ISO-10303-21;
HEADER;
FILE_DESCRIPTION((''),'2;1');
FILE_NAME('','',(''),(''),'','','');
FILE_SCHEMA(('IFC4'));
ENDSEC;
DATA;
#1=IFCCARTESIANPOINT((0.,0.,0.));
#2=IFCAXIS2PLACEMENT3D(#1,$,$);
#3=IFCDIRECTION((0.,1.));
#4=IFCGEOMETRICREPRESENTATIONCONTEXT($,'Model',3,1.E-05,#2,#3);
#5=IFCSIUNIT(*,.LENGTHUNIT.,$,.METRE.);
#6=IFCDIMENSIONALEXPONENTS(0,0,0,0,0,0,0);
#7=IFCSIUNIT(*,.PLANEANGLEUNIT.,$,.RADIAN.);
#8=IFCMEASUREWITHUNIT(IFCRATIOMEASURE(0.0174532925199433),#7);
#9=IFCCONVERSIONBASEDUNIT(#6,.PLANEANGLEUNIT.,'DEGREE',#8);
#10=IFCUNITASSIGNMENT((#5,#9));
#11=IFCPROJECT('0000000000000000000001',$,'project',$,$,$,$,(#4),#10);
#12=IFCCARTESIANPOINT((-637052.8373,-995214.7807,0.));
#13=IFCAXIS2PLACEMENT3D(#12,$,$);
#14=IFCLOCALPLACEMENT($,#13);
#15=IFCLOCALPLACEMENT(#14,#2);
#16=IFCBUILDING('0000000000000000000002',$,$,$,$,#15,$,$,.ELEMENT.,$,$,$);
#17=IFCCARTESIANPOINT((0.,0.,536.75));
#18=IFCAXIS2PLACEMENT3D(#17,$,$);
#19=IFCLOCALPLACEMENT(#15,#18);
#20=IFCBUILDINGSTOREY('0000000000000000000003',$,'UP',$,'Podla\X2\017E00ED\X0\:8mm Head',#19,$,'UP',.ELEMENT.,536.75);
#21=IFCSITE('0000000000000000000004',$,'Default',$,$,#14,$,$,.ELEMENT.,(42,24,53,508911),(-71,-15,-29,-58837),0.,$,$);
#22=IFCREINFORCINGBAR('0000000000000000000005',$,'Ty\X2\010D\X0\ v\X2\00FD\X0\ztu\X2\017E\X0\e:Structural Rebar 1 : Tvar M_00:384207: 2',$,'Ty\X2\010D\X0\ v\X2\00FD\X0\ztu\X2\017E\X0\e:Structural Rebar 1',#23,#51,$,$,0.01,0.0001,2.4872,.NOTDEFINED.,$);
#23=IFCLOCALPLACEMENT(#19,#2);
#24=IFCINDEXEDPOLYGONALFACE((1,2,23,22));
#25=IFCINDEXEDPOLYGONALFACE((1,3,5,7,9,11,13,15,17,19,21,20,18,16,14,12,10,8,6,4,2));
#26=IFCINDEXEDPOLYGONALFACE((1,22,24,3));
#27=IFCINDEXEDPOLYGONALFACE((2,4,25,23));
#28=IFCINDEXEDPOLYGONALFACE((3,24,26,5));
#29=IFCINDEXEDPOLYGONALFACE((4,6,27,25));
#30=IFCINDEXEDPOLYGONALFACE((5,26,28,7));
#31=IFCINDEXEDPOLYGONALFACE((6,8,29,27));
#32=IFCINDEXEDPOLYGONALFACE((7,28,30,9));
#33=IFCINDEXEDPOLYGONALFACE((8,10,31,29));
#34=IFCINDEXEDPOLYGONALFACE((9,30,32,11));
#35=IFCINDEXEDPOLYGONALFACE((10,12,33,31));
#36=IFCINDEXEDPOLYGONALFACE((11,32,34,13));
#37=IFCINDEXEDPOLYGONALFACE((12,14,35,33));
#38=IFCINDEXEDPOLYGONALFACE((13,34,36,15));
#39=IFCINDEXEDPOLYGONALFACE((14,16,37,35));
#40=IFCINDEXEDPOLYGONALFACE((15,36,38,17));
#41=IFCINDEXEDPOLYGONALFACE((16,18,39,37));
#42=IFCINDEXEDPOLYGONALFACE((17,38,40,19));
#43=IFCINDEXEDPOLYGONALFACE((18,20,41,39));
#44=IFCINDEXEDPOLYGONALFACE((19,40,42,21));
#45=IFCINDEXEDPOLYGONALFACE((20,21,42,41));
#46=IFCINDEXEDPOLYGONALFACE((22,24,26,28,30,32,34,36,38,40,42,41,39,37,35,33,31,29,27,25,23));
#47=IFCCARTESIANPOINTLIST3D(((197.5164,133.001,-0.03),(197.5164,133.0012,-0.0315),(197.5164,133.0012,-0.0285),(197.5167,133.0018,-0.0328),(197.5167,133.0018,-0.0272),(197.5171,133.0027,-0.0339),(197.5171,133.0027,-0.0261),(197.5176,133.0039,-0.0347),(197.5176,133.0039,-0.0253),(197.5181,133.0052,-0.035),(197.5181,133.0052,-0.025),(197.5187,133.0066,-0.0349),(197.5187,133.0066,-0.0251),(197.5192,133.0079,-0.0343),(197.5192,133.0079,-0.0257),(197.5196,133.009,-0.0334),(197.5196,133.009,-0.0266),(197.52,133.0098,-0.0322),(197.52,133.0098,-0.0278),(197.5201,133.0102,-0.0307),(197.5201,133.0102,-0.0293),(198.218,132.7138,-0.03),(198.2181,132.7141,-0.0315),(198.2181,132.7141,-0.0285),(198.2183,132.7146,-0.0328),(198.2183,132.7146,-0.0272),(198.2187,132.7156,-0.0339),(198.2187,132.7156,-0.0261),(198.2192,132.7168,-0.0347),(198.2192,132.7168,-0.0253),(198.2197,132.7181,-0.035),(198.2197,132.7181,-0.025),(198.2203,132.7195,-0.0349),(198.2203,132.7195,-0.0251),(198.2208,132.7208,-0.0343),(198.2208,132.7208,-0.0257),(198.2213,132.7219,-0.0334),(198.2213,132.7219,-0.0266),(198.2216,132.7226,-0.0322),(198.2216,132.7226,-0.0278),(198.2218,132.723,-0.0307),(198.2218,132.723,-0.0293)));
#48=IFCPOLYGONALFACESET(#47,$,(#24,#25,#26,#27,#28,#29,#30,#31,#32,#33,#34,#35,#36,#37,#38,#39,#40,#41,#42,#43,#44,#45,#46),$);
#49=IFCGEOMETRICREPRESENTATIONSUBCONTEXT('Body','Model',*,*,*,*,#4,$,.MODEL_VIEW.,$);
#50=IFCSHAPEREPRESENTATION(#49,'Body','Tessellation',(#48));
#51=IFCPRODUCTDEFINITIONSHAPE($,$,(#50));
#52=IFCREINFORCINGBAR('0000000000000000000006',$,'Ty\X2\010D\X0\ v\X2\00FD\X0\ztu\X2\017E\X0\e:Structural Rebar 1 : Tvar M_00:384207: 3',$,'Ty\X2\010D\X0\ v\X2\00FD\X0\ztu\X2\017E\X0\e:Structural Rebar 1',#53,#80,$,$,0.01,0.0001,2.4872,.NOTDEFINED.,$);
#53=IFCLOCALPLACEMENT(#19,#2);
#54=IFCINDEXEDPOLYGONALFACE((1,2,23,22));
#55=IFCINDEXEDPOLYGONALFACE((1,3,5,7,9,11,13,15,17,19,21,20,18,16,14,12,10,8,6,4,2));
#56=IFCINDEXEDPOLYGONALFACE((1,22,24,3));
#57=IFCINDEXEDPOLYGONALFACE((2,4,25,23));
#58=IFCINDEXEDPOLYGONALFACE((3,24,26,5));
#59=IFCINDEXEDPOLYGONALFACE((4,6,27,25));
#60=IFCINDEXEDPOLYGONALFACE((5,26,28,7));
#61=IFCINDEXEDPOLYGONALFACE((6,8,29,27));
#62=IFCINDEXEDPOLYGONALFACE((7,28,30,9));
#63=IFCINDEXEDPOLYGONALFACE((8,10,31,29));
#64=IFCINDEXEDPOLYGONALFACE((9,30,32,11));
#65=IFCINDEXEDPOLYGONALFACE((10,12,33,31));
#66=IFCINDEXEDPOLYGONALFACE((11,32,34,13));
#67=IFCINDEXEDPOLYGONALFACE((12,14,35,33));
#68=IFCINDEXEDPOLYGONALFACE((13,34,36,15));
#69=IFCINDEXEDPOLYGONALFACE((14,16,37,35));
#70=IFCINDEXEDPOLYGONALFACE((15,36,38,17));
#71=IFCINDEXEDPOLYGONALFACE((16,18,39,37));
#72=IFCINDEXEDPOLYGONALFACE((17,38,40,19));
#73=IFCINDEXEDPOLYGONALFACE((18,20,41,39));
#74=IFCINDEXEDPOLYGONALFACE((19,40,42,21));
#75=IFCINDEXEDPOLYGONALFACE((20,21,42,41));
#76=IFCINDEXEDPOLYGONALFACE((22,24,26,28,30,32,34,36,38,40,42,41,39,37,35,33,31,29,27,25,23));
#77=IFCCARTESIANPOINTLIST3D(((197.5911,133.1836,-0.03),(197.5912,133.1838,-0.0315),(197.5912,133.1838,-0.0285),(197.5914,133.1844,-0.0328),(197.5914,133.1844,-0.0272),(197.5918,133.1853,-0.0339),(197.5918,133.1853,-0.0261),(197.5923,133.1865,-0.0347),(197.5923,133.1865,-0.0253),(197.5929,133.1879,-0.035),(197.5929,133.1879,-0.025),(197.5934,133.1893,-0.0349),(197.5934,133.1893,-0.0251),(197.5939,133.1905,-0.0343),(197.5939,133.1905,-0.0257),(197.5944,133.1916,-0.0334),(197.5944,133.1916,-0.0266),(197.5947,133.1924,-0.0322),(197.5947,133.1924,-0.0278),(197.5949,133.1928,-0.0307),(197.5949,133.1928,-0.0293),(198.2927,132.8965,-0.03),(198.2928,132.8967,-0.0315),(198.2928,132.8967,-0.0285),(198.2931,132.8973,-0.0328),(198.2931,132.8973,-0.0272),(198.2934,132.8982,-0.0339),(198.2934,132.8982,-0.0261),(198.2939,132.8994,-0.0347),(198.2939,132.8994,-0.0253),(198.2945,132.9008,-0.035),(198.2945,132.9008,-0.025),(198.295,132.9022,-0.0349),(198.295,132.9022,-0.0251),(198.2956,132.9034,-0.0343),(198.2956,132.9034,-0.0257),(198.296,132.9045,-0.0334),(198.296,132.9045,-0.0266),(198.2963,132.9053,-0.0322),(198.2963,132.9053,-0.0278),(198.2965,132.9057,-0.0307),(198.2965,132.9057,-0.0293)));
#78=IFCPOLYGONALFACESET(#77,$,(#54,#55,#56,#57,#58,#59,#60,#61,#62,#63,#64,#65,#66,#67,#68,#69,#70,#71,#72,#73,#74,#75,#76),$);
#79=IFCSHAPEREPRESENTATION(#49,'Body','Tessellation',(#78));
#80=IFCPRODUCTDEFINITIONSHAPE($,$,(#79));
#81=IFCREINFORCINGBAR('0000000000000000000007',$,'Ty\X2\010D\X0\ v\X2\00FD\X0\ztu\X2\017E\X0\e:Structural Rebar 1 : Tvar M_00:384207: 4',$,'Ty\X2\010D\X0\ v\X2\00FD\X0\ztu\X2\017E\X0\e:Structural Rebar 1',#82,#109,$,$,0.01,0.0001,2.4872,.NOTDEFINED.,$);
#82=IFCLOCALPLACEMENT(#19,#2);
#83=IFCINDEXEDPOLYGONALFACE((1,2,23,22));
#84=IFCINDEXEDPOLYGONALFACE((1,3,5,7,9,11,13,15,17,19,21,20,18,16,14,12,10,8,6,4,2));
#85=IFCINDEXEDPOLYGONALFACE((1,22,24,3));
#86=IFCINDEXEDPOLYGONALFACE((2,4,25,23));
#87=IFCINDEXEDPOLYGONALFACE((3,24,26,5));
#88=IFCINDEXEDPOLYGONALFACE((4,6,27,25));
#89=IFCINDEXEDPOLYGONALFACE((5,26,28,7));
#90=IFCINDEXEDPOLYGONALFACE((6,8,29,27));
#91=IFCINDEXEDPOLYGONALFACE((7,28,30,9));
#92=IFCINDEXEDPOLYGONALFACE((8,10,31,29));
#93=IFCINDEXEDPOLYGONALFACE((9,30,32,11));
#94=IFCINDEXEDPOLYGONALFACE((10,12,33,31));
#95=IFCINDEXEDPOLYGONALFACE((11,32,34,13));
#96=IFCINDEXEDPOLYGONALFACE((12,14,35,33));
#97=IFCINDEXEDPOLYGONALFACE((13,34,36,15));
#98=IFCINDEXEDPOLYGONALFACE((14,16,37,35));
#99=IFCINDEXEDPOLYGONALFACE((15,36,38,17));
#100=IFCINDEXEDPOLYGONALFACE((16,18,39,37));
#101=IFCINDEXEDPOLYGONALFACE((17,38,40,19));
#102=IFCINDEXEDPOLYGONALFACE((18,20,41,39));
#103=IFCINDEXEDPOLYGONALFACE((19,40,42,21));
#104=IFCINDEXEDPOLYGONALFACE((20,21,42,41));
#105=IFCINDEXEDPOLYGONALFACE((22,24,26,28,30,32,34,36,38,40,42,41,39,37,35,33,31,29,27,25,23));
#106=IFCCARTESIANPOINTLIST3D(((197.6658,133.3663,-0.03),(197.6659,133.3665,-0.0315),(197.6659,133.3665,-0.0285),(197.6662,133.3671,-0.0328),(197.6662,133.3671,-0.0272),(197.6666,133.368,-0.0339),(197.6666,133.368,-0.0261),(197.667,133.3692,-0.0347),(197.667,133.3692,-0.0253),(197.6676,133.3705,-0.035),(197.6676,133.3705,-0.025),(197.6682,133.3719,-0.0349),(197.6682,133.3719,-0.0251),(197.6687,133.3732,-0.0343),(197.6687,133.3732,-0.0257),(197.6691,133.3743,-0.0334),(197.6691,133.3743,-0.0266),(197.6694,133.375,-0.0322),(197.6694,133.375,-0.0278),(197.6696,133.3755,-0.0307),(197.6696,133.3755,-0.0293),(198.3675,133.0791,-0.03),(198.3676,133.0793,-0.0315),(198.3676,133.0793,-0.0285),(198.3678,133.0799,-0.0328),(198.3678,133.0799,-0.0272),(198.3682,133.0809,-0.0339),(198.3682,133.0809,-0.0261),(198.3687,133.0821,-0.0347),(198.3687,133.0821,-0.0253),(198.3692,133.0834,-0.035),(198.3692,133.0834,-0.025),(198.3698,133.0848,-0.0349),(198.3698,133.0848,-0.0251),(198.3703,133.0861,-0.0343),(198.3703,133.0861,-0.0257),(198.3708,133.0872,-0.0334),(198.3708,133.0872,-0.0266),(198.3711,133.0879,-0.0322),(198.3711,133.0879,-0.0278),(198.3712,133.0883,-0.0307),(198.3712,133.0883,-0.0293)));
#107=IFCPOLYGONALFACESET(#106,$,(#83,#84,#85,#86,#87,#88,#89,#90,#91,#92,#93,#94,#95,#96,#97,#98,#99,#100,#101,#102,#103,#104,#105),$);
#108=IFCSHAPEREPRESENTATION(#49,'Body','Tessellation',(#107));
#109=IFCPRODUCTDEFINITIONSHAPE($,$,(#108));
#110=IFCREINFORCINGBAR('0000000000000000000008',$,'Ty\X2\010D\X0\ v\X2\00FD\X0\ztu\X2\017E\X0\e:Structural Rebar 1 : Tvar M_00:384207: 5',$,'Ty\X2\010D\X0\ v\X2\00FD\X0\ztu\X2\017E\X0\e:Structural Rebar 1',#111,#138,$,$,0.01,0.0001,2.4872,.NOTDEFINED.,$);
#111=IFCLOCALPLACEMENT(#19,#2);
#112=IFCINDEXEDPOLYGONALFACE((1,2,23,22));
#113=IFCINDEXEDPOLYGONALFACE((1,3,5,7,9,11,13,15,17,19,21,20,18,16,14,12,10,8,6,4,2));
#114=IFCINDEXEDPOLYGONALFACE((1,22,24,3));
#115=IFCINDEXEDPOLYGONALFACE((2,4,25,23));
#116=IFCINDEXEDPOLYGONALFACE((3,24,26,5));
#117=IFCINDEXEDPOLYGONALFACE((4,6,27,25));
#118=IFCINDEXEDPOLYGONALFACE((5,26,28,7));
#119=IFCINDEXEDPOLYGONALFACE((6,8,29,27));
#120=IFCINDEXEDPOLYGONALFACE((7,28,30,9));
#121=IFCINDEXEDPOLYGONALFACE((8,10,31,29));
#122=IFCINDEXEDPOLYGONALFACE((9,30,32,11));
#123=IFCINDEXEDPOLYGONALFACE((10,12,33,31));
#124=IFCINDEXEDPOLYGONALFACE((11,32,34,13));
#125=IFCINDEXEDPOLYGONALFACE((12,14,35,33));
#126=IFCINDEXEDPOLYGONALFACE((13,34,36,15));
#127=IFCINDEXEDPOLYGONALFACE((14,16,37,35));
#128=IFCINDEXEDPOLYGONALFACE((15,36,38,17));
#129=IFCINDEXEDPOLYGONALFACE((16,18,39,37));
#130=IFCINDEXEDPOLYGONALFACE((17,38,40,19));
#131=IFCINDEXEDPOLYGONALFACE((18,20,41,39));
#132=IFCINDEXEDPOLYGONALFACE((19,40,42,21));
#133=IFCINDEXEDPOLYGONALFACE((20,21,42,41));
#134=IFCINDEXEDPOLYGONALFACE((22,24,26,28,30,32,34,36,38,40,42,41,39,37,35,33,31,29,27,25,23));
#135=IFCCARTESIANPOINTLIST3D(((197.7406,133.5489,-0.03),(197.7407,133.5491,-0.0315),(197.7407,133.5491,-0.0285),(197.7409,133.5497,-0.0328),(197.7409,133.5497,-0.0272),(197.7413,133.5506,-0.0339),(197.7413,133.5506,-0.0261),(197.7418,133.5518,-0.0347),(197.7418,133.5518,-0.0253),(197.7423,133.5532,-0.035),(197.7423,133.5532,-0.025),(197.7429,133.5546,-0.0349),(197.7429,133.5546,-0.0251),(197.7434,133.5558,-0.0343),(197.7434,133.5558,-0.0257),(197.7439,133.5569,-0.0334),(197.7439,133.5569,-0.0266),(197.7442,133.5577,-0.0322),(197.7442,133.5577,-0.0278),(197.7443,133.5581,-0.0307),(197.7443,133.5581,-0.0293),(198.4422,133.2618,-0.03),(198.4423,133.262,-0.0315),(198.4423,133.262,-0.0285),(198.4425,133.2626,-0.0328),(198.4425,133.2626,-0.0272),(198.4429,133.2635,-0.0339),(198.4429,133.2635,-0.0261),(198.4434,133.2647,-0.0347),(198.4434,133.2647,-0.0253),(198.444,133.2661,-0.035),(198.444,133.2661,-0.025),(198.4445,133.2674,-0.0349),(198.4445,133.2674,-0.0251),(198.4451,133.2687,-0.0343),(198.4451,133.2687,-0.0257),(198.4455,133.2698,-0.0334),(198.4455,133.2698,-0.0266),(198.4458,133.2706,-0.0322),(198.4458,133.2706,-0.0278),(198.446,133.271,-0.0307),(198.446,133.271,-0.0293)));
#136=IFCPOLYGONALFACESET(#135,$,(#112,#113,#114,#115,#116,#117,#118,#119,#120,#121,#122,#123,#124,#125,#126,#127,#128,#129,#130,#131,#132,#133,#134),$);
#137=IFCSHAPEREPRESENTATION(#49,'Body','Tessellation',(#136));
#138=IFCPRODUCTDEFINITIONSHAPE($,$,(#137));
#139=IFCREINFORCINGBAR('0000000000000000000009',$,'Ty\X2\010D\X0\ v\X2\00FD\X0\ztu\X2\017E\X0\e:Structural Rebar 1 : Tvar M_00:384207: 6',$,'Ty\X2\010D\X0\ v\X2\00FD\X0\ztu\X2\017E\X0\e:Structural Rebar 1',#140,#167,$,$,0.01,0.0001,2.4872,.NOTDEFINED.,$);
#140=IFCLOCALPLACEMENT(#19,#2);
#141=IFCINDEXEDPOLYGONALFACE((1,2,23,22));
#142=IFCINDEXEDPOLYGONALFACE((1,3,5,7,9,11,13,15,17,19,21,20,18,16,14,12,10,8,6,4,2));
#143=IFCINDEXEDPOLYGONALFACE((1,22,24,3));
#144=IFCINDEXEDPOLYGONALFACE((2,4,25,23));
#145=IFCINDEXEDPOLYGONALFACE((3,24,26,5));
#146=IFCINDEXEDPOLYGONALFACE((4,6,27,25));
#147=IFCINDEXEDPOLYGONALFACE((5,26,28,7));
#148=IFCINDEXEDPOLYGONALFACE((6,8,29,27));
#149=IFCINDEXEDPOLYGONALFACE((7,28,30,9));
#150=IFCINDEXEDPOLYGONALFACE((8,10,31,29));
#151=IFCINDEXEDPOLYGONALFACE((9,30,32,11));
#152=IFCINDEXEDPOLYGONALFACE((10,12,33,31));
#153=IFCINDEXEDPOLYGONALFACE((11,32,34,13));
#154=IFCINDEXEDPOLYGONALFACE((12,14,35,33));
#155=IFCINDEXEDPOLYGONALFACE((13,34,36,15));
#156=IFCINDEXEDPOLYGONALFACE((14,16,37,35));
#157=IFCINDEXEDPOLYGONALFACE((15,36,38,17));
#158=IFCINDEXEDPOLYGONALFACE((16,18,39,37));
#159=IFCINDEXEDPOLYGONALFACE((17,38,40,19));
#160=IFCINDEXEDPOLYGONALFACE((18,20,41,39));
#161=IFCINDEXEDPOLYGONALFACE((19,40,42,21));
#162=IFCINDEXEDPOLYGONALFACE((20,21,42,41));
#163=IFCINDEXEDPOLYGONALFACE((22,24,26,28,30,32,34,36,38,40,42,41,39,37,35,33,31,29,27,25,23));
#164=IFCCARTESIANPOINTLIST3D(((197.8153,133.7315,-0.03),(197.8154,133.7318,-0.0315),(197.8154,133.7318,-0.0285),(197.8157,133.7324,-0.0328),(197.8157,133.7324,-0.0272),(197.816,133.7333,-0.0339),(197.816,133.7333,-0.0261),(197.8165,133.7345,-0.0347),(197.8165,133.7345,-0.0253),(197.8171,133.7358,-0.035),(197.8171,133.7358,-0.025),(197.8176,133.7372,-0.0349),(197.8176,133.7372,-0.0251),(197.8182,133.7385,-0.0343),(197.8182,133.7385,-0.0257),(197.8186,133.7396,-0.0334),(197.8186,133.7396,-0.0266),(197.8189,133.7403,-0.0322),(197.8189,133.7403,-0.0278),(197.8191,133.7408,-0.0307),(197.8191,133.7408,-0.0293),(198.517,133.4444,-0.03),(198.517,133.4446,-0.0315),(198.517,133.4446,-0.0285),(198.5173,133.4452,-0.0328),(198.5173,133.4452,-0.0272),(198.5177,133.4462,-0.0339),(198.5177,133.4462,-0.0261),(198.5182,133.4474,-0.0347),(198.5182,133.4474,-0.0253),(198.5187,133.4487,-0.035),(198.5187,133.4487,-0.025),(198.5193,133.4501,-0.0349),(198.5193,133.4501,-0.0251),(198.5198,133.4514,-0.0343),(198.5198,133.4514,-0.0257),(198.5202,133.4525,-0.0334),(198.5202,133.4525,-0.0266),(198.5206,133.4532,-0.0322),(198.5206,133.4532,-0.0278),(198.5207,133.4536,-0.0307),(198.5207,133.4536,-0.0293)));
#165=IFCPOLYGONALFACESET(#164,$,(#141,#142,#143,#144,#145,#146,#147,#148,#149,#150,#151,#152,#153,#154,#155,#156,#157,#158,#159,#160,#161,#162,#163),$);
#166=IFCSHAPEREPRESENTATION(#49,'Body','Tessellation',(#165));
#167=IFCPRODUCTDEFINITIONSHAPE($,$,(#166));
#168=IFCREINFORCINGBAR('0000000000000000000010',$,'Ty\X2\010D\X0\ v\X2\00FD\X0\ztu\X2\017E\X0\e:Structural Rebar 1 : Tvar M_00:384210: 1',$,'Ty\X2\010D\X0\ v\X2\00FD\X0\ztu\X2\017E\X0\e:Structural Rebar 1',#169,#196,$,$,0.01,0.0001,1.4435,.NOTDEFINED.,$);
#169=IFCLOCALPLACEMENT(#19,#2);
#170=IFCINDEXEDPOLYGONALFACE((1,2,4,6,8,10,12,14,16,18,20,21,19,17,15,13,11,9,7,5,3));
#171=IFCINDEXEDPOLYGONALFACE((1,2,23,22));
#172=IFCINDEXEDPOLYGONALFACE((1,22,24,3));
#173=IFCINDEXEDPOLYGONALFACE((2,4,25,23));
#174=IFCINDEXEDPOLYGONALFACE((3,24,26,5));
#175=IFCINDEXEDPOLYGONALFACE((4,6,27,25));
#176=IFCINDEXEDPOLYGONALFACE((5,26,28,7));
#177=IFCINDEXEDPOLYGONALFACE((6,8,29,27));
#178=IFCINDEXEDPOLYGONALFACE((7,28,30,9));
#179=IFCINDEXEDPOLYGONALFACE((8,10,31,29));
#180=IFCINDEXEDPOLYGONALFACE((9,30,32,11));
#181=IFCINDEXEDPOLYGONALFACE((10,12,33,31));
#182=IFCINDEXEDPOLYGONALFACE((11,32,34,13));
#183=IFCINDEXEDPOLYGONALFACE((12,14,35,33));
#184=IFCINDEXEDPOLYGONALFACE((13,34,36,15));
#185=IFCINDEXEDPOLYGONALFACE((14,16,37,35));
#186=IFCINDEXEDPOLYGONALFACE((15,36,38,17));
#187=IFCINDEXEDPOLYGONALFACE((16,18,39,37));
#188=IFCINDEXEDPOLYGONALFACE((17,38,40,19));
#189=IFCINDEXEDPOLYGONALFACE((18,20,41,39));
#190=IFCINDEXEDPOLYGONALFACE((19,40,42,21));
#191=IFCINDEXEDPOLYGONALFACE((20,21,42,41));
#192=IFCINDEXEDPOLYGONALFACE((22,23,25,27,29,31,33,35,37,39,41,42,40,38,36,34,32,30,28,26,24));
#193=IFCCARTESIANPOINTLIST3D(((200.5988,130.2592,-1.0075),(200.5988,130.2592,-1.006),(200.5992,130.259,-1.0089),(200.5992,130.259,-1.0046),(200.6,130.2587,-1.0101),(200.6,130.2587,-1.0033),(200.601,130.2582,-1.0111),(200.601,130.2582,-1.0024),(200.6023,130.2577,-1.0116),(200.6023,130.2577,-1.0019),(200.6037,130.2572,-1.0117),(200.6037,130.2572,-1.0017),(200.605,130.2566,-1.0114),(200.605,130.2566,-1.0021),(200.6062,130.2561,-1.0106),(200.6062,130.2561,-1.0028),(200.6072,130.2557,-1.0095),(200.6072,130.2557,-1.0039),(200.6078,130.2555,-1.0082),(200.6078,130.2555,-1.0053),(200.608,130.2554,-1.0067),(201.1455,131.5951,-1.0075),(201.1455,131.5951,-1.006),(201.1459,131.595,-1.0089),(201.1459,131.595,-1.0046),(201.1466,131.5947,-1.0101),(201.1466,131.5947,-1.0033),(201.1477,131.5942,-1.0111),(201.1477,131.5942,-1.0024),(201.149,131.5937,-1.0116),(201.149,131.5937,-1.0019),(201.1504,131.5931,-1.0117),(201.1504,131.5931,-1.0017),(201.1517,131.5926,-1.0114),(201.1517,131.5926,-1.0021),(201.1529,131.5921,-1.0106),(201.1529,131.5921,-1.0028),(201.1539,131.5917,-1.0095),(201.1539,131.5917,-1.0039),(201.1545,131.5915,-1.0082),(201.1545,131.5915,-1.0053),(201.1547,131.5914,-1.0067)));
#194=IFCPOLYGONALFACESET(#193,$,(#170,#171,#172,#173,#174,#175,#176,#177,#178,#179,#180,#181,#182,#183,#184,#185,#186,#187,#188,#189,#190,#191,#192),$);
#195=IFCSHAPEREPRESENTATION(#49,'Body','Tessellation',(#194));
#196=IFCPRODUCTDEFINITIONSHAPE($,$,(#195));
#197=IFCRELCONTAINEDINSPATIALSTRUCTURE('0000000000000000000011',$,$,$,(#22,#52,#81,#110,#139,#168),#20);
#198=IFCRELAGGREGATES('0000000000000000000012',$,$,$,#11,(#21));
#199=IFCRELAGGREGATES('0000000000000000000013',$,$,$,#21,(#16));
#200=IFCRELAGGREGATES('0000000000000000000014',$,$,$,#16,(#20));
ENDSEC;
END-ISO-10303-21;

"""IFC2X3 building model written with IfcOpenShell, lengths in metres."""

from ifc_helpers import new_model, entity, si_unit, converted_unit, direction, frame, origin, place, context, subcontext, project, spatial, element, save


model = new_model("IFC2X3")

# Units and contexts
model_context = context("Model", 3, precision=1e-05, world=origin(), true_north=direction((0.0, 1.0)))
body_context = subcontext(model_context, "Body", "Model", "MODEL_VIEW")
ifc_project = project(units=[si_unit("LENGTHUNIT", "METRE"), converted_unit("PLANEANGLEUNIT", "DEGREE", entity("IfcRatioMeasure", 0.0174532925199433), si_unit("PLANEANGLEUNIT", "RADIAN"), dimensions=[0, 0, 0, 0, 0, 0, 0])], contexts=[model_context])

# Site, building, storey
site_placement = place(None, frame((-637052.8373, -995214.7807, 0.0)))
site = spatial("IfcSite", under=ifc_project, at=site_placement, Name="Default", CompositionType="ELEMENT", RefLatitude=(42, 24, 53, 508911), RefLongitude=(-71, -15, -29, -58837), RefElevation=0.0)
building_placement = place(site_placement, origin())
building = spatial("IfcBuilding", under=site, at=building_placement, CompositionType="ELEMENT")
storey_placement = place(building_placement, frame((0.0, 0.0, 536.75)))
storey = spatial("IfcBuildingStorey", under=building, at=storey_placement, Name="UP", ObjectType="Podlaží:8mm Head", LongName="UP", CompositionType="ELEMENT", Elevation=536.75)

# Reinforcing bars
reinforcing_bar_1_placement = place(storey_placement, origin())
element("IfcReinforcingBar", 1, at=reinforcing_bar_1_placement, inside=storey, Name="Tyč výztuže:Structural Rebar 1 : Tvar M_00:384207: 2", ObjectType="Tyč výztuže:Structural Rebar 1", BarLength=2.4872, BarRole="NOTDEFINED", CrossSectionArea=0.0001, NominalDiameter=0.01, context=body_context, shape_type="AdvancedSweptSolid", body=[
    entity("IfcSweptDiskSolid", entity("IfcCompositeCurve", [entity("IfcCompositeCurveSegment", "CONTINUOUS", True, entity("IfcPolyline", [entity("IfcCartesianPoint", [-197.5183, -133.0056, 0.03]), entity("IfcCartesianPoint", [-198.2199, -132.7185, 0.03])]))], False), 0.005, None, 0.0, 1.0),
])
reinforcing_bar_2_placement = place(storey_placement, origin())
element("IfcReinforcingBar", 2, at=reinforcing_bar_2_placement, inside=storey, Name="Tyč výztuže:Structural Rebar 1 : Tvar M_00:384207: 3", ObjectType="Tyč výztuže:Structural Rebar 1", BarLength=2.4872, BarRole="NOTDEFINED", CrossSectionArea=0.0001, NominalDiameter=0.01, context=body_context, shape_type="AdvancedSweptSolid", body=[
    entity("IfcSweptDiskSolid", entity("IfcCompositeCurve", [entity("IfcCompositeCurveSegment", "CONTINUOUS", True, entity("IfcPolyline", [entity("IfcCartesianPoint", [-197.593, -133.1882, 0.03]), entity("IfcCartesianPoint", [-198.2946, -132.9011, 0.03])]))], False), 0.005, None, 0.0, 1.0),
])
reinforcing_bar_3_placement = place(storey_placement, origin())
element("IfcReinforcingBar", 3, at=reinforcing_bar_3_placement, inside=storey, Name="Tyč výztuže:Structural Rebar 1 : Tvar M_00:384207: 4", ObjectType="Tyč výztuže:Structural Rebar 1", BarLength=2.4872, BarRole="NOTDEFINED", CrossSectionArea=0.0001, NominalDiameter=0.01, context=body_context, shape_type="AdvancedSweptSolid", body=[
    entity("IfcSweptDiskSolid", entity("IfcCompositeCurve", [entity("IfcCompositeCurveSegment", "CONTINUOUS", True, entity("IfcPolyline", [entity("IfcCartesianPoint", [-197.6677, -133.3709, 0.03]), entity("IfcCartesianPoint", [-198.3694, -133.0838, 0.03])]))], False), 0.005, None, 0.0, 1.0),
])
reinforcing_bar_4_placement = place(storey_placement, origin())
element("IfcReinforcingBar", 4, at=reinforcing_bar_4_placement, inside=storey, Name="Tyč výztuže:Structural Rebar 1 : Tvar M_00:384207: 5", ObjectType="Tyč výztuže:Structural Rebar 1", BarLength=2.4872, BarRole="NOTDEFINED", CrossSectionArea=0.0001, NominalDiameter=0.01, context=body_context, shape_type="AdvancedSweptSolid", body=[
    entity("IfcSweptDiskSolid", entity("IfcCompositeCurve", [entity("IfcCompositeCurveSegment", "CONTINUOUS", True, entity("IfcPolyline", [entity("IfcCartesianPoint", [-197.7425, -133.5535, 0.03]), entity("IfcCartesianPoint", [-198.4441, -133.2664, 0.03])]))], False), 0.005, None, 0.0, 1.0),
])
reinforcing_bar_5_placement = place(storey_placement, origin())
element("IfcReinforcingBar", 5, at=reinforcing_bar_5_placement, inside=storey, Name="Tyč výztuže:Structural Rebar 1 : Tvar M_00:384207: 6", ObjectType="Tyč výztuže:Structural Rebar 1", BarLength=2.4872, BarRole="NOTDEFINED", CrossSectionArea=0.0001, NominalDiameter=0.01, context=body_context, shape_type="AdvancedSweptSolid", body=[
    entity("IfcSweptDiskSolid", entity("IfcCompositeCurve", [entity("IfcCompositeCurveSegment", "CONTINUOUS", True, entity("IfcPolyline", [entity("IfcCartesianPoint", [-197.8172, -133.7362, 0.03]), entity("IfcCartesianPoint", [-198.5188, -133.4491, 0.03])]))], False), 0.005, None, 0.0, 1.0),
])
reinforcing_bar_6_placement = place(storey_placement, origin())
element("IfcReinforcingBar", 6, at=reinforcing_bar_6_placement, inside=storey, Name="Tyč výztuže:Structural Rebar 1 : Tvar M_00:384210: 1", ObjectType="Tyč výztuže:Structural Rebar 1", BarLength=1.4435, BarRole="NOTDEFINED", CrossSectionArea=0.0001, NominalDiameter=0.01, context=body_context, shape_type="AdvancedSweptSolid", body=[
    entity("IfcSweptDiskSolid", entity("IfcCompositeCurve", [entity("IfcCompositeCurveSegment", "CONTINUOUS", True, entity("IfcPolyline", [entity("IfcCartesianPoint", [-201.15, -131.5933, 1.0067]), entity("IfcCartesianPoint", [-200.6033, -130.2573, 1.0067])]))], False), 0.005, None, 0.0, 1.0),
])

save(model, "model.ifc")
